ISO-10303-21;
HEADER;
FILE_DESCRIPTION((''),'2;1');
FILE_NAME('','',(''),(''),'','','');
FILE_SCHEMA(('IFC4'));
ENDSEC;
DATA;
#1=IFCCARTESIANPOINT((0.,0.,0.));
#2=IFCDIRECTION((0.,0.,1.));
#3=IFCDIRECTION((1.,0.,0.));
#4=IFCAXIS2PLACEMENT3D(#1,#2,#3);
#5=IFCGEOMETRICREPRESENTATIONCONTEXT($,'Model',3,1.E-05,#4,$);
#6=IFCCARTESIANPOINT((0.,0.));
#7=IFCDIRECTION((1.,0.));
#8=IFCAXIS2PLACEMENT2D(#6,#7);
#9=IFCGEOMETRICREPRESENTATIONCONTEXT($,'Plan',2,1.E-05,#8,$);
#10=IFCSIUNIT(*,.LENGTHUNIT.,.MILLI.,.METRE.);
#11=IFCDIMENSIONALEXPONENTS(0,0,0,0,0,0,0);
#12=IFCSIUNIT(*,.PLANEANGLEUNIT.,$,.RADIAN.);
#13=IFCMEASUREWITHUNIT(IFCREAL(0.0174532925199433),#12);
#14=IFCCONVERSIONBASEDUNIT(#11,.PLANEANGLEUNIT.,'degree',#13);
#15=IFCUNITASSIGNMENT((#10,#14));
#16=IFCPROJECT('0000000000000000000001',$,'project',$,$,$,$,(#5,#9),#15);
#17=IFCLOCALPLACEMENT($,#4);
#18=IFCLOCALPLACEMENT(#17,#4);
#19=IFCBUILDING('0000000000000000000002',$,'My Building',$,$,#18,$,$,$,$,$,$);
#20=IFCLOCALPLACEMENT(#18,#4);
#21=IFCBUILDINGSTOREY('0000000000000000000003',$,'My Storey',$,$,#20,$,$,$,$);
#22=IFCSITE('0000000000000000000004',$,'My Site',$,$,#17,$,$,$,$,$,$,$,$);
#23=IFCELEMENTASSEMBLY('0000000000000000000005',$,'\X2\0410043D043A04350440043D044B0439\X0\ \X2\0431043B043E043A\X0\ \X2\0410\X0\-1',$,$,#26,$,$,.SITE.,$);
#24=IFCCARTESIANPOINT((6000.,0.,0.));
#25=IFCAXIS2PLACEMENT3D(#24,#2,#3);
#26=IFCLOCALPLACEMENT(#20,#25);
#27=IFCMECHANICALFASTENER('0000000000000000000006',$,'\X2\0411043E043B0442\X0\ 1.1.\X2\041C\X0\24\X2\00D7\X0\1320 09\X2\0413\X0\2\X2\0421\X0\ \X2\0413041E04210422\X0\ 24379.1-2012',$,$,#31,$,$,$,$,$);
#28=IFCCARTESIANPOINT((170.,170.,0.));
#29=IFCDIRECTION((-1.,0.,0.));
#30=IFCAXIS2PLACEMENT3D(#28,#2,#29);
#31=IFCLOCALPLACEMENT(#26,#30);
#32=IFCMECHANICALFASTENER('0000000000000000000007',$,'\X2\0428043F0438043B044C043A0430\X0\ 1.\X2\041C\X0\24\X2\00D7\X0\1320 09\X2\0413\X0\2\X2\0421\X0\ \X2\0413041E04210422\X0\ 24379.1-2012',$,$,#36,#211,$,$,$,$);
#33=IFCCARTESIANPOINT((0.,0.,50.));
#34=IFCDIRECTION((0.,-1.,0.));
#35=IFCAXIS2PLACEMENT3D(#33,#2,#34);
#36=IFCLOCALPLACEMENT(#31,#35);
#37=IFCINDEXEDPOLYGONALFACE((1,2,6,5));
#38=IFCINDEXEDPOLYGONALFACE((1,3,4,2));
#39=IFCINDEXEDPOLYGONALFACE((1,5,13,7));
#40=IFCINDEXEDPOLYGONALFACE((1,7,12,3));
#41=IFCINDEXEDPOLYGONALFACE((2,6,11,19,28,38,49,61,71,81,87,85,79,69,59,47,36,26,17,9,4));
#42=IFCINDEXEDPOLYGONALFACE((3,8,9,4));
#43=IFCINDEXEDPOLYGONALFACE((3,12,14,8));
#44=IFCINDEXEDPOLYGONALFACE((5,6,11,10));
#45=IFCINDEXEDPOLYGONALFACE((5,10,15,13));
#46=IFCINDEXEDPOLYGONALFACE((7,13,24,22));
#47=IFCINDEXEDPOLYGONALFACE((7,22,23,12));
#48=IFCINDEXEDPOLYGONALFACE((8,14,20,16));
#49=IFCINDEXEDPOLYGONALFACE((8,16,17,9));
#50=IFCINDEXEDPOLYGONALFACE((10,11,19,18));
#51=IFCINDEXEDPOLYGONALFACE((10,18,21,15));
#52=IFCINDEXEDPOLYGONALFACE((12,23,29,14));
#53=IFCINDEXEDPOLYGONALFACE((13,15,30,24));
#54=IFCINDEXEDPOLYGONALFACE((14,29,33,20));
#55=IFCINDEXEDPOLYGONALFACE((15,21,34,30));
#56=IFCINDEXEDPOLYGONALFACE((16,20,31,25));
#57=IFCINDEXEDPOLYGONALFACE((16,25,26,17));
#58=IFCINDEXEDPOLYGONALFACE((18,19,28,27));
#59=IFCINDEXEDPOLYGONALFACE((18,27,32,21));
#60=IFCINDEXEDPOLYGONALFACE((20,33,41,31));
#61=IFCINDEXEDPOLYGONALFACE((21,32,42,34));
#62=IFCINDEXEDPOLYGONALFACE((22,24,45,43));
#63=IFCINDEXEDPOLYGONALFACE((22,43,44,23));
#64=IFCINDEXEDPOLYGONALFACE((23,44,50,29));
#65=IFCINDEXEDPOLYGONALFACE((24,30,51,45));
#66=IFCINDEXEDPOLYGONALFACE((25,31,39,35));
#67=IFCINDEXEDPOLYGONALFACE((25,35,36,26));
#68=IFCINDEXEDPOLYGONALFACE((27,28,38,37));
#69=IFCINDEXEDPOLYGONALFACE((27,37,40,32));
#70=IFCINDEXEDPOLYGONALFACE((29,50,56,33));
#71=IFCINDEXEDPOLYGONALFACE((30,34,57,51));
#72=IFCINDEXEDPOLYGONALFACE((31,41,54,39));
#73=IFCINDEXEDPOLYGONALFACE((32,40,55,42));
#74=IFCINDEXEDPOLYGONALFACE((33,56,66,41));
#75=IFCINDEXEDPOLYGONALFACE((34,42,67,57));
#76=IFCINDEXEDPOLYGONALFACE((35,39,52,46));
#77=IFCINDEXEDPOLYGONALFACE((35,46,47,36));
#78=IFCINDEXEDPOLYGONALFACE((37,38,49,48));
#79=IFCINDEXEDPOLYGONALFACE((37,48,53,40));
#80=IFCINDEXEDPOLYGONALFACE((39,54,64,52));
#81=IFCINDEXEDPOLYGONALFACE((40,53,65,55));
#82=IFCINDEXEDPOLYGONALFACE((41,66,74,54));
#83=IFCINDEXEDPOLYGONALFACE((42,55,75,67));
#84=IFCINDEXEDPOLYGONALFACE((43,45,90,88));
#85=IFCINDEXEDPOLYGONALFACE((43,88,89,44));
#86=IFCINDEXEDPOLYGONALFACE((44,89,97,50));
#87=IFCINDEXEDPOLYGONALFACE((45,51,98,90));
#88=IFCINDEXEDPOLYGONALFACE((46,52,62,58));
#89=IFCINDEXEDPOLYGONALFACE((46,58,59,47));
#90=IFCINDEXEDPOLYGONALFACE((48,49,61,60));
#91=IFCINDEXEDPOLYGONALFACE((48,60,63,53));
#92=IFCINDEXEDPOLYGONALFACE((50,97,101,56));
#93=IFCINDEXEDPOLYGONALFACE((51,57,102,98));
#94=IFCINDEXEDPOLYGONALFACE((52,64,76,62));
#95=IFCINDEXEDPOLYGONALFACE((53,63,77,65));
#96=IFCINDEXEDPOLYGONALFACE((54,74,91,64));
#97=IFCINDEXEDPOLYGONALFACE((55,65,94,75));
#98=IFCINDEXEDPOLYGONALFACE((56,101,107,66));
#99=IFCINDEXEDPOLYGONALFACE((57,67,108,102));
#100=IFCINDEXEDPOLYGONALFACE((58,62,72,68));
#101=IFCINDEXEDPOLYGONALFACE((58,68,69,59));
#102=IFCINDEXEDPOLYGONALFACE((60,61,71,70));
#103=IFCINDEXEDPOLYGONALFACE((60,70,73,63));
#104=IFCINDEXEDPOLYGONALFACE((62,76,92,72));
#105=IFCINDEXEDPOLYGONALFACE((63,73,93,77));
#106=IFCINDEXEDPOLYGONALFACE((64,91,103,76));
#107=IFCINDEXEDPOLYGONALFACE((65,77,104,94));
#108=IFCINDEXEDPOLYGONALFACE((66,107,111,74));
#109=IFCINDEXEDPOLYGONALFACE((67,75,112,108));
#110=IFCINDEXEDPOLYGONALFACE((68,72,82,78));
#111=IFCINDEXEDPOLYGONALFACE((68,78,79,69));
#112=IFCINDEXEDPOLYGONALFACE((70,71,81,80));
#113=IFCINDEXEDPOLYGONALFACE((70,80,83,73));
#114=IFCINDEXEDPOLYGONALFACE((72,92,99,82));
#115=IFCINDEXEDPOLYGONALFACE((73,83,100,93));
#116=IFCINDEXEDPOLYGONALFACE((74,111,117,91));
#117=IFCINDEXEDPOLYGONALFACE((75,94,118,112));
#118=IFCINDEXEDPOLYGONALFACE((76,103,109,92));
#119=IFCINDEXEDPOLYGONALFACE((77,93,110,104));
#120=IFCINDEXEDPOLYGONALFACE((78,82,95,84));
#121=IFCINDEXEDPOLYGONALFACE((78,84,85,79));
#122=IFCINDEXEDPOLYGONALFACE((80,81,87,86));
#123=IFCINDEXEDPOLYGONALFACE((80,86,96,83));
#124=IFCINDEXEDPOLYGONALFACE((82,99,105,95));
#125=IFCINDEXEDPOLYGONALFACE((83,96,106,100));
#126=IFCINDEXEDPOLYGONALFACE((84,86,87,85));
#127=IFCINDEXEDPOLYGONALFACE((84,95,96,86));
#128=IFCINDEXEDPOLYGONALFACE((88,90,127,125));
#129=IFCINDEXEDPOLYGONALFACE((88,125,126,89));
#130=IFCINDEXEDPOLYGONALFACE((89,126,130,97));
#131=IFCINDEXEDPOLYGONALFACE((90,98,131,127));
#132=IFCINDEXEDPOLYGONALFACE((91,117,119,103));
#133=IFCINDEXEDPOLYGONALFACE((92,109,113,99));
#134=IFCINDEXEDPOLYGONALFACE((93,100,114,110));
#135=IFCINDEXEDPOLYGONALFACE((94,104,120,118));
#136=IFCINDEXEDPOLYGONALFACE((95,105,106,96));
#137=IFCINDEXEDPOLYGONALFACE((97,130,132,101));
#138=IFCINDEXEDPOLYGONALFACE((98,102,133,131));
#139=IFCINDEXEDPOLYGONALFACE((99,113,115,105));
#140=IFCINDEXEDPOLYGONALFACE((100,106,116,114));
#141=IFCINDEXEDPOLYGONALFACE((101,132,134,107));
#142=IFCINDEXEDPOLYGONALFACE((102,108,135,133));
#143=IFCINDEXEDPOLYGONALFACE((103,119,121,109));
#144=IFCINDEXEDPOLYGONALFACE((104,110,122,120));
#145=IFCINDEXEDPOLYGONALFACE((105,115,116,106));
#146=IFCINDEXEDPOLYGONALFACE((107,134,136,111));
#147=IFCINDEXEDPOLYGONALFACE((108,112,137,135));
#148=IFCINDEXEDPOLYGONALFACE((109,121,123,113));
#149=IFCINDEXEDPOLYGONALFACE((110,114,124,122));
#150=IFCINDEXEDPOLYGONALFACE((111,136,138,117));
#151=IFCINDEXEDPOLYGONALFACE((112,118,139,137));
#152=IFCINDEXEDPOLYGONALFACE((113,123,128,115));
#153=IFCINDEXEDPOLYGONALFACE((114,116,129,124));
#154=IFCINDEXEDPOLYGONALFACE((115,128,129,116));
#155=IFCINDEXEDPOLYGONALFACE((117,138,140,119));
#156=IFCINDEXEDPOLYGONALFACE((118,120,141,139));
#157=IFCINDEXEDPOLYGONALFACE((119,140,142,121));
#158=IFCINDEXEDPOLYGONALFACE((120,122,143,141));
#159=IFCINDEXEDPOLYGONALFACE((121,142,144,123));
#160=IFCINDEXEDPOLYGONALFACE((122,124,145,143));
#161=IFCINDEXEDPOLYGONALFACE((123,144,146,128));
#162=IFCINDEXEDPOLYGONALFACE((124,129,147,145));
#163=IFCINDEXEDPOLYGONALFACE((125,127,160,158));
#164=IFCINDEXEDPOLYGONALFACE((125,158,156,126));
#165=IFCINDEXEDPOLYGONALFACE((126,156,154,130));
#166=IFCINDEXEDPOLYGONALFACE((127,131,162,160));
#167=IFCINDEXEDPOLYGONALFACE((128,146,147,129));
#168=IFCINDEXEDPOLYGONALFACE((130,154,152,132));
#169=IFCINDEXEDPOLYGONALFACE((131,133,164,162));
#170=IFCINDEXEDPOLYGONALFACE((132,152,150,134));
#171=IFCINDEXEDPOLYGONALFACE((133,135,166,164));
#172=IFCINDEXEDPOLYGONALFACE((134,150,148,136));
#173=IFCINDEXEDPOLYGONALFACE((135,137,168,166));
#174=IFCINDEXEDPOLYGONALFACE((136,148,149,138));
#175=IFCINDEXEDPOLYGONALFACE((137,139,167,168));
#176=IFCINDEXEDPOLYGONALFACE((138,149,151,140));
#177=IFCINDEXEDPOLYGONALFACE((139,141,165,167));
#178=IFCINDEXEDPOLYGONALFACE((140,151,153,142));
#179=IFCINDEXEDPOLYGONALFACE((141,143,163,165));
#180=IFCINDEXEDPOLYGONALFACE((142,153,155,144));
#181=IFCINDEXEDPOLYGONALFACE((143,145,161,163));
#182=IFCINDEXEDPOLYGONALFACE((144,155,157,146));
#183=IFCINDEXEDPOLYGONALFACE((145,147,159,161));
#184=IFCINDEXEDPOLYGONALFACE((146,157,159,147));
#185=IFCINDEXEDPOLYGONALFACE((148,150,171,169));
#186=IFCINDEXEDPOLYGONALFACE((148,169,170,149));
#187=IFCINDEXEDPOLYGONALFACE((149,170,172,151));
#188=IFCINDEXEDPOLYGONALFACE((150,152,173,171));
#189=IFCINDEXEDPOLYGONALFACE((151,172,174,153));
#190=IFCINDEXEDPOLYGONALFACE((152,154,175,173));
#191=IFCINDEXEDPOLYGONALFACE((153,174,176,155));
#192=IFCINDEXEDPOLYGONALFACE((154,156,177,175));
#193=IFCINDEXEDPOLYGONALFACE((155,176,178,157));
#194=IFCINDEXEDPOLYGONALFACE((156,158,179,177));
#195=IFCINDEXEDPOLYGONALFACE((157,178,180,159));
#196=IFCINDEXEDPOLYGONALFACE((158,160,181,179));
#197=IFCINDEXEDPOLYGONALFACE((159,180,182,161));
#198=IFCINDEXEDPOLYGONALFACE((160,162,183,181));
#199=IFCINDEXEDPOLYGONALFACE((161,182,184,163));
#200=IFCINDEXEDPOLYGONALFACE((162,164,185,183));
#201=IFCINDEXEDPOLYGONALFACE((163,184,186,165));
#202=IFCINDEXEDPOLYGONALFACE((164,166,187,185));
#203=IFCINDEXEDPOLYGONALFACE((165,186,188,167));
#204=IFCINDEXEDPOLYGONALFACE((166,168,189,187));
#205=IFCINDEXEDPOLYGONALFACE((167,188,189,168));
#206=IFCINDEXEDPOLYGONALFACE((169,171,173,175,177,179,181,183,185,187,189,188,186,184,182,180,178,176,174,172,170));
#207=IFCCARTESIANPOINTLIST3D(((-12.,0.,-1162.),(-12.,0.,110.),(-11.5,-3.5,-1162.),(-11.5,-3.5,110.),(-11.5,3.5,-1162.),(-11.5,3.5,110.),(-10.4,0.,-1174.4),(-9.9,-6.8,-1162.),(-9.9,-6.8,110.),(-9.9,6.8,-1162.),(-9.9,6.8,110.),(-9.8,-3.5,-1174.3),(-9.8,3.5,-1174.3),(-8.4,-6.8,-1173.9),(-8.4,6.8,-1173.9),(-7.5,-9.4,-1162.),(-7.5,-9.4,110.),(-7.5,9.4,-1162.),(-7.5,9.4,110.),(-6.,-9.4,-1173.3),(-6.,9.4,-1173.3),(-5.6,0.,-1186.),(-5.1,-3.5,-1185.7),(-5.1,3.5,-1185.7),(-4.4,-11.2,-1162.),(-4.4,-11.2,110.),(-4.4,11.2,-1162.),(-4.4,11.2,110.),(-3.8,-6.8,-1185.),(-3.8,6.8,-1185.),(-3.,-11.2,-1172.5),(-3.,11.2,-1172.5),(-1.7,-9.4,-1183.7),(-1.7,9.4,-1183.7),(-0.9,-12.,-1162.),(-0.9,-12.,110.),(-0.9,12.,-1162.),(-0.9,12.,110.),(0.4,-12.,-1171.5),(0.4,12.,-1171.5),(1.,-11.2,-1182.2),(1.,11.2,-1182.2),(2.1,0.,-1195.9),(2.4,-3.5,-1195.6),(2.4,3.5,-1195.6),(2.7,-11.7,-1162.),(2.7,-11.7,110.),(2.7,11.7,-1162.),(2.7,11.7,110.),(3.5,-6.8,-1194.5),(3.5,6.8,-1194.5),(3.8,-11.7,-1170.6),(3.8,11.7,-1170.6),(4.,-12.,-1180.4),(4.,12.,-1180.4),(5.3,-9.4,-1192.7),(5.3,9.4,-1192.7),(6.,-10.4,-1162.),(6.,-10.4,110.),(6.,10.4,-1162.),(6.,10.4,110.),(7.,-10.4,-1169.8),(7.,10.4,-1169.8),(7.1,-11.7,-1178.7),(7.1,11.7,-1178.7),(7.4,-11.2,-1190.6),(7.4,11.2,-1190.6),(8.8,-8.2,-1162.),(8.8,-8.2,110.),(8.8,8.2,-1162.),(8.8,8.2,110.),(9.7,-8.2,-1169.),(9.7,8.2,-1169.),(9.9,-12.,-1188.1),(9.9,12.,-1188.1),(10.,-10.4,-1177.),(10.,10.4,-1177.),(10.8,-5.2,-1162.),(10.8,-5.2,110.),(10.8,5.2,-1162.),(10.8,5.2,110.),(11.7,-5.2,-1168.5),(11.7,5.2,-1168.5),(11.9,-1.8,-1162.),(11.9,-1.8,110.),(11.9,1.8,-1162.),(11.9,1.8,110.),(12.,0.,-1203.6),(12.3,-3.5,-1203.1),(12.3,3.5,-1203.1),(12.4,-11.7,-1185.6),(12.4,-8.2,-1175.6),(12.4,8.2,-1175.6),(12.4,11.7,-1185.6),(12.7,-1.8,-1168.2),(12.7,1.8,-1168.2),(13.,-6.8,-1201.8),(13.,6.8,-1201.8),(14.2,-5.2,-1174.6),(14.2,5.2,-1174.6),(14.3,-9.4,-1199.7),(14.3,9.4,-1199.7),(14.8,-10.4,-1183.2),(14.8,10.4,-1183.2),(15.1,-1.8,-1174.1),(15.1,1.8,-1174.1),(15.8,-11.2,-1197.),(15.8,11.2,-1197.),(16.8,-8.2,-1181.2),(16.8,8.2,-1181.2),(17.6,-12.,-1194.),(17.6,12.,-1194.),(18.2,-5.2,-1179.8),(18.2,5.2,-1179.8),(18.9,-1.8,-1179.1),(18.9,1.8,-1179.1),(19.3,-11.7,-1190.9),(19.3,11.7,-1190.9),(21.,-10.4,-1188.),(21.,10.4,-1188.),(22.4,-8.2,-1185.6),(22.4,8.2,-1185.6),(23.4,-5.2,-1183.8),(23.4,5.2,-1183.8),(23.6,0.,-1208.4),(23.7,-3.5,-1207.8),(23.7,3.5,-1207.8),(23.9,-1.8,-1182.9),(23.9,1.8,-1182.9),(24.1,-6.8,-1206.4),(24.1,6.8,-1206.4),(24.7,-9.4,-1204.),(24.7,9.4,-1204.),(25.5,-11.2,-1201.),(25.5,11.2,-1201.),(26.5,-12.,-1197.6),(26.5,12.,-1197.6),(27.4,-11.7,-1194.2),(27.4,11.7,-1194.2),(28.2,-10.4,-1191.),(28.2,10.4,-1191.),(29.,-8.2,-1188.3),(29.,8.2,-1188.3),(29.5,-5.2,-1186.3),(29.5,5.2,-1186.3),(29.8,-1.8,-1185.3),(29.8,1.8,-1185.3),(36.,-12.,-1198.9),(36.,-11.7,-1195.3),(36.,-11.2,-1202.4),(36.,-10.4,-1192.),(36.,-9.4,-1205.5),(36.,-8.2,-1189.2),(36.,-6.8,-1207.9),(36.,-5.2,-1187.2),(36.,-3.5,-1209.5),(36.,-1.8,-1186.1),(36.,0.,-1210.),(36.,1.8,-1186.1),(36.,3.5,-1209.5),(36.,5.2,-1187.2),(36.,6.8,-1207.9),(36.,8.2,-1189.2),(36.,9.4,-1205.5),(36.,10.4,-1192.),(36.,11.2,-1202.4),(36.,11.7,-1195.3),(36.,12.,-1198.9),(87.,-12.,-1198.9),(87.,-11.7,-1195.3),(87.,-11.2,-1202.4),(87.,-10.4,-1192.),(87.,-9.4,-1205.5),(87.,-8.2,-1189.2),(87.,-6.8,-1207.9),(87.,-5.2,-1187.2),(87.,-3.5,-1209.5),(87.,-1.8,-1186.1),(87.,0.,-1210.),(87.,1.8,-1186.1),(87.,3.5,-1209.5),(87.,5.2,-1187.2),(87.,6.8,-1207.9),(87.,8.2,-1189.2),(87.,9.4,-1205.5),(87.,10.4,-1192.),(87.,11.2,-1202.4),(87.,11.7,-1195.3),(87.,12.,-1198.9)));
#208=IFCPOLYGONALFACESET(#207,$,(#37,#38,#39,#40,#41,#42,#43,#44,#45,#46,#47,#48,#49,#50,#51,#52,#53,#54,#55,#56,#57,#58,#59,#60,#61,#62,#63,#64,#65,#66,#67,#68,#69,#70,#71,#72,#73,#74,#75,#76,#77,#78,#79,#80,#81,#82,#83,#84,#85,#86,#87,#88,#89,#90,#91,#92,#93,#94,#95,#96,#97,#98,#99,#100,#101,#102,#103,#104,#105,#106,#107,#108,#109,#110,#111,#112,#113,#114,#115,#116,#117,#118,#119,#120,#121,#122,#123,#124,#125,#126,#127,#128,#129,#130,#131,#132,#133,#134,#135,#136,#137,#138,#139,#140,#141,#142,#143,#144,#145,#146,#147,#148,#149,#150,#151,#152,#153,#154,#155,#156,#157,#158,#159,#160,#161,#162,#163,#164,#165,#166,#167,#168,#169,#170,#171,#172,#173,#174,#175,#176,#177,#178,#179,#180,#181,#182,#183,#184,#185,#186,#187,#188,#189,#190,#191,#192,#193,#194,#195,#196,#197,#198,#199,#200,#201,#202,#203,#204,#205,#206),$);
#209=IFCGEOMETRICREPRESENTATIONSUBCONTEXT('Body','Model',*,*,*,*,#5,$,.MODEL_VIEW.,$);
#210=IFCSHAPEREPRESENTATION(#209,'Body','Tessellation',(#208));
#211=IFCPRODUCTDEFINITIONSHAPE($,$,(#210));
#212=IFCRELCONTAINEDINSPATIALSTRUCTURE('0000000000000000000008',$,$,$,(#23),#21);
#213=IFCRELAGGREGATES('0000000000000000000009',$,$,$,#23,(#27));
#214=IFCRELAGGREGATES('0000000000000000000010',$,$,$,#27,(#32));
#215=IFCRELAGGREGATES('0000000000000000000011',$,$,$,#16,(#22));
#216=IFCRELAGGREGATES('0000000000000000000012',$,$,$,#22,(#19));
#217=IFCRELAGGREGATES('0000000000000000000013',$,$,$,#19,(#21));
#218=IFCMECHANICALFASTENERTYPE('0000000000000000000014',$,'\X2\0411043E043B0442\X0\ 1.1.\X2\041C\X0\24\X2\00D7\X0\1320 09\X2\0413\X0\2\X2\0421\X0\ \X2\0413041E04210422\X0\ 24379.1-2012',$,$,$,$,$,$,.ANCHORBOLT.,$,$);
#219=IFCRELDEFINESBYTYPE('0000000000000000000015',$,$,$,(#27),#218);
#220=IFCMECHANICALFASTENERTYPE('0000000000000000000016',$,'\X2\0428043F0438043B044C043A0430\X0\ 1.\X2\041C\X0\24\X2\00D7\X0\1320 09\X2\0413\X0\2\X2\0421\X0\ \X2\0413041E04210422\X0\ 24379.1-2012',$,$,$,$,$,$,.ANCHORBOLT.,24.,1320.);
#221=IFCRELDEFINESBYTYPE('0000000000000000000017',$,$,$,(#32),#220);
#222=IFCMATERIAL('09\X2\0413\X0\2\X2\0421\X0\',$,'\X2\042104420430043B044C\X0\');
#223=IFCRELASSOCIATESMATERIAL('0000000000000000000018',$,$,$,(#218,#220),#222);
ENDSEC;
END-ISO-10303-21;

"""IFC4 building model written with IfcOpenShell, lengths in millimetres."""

from ifc_helpers import new_model, entity, si_unit, converted_unit, frame, origin_with_axes, origin_2d_with_axis, place, context, subcontext, project, spatial, source, transform, mapped, material, type_object, type_shapes, element, aggregate, save


model = new_model("IFC4")

# Units and contexts
model_context = context("Model", 3, precision=1e-05, world=origin_with_axes())
plan_context = context("Plan", 2, precision=1e-05, world=origin_2d_with_axis())
body_context = subcontext(model_context, "Body", "Model", "MODEL_VIEW")
ifc_project = project(units=[si_unit("LENGTHUNIT", "METRE", prefix="MILLI"), converted_unit("PLANEANGLEUNIT", "degree", entity("IfcReal", 0.0174532925199433), si_unit("PLANEANGLEUNIT", "RADIAN"), dimensions=[0, 0, 0, 0, 0, 0, 0])], contexts=[model_context, plan_context])

# Site, building, storey
site_placement = place(None, origin_with_axes())
site = spatial("IfcSite", under=ifc_project, at=site_placement, Name="My Site")
building_placement = place(site_placement, origin_with_axes())
building = spatial("IfcBuilding", under=site, at=building_placement, Name="My Building")
storey_placement = place(building_placement, origin_with_axes())
storey = spatial("IfcBuildingStorey", under=building, at=storey_placement, Name="My Storey")

# Element assembly, mechanical fasteners
assembly_1_placement = place(storey_placement, frame((6000.0, 0.0, 0.0), z_axis=(0.0, 0.0, 1.0), x_axis=(1.0, 0.0, 0.0)))
assembly_1 = element("IfcElementAssembly", 1, at=assembly_1_placement, inside=storey, Name="Анкерный блок А-1", AssemblyPlace="SITE")
ifc_material_1 = material(Name="09Г2С", Category="Сталь")
mechanical_fastener_type_1 = type_object("IfcMechanicalFastenerType", Name="Болт 1.1.М24×1320 09Г2С ГОСТ 24379.1-2012", PredefinedType="ANCHORBOLT", material=ifc_material_1)
mechanical_fastener_type_2 = type_object("IfcMechanicalFastenerType", Name="Шпилька 1.М24×1320 09Г2С ГОСТ 24379.1-2012", NominalDiameter=24.0, NominalLength=1320.0, PredefinedType="ANCHORBOLT", material=ifc_material_1)
shared_shape_1 = source(frame((0.0, 0.0, 110.0), z_axis=(0.0, 0.0, 1.0), x_axis=(1.0, 0.0, 0.0)), body_context, "Body", "AdvancedSweptSolid", [
    entity("IfcSweptDiskSolid", entity("IfcIndexedPolyCurve", entity("IfcCartesianPointList3D", [[0.0, 0.0, 0.0], [0.0, 0.0, -1272.0], [10.5, 0.0, -1297.5], [36.0, 0.0, -1308.0], [87.0, 0.0, -1308.0]]), [entity("IfcLineIndex", [1, 2]), entity("IfcArcIndex", [2, 3, 4]), entity("IfcLineIndex", [4, 5])]), 12.0),
])
type_shapes(mechanical_fastener_type_2, [shared_shape_1])
mechanical_fastener_1_placement = place(assembly_1_placement, frame((170.0, 170.0, 0.0), z_axis=(0.0, 0.0, 1.0), x_axis=(-1.0, 0.0, 0.0)))
mechanical_fastener_1 = element("IfcMechanicalFastener", 2, at=mechanical_fastener_1_placement, type_object=mechanical_fastener_type_1, Name="Болт 1.1.М24×1320 09Г2С ГОСТ 24379.1-2012")
mechanical_fastener_2_placement = place(mechanical_fastener_1_placement, frame((0.0, 0.0, 50.0), z_axis=(0.0, 0.0, 1.0), x_axis=(0.0, -1.0, 0.0)))
mechanical_fastener_2 = element("IfcMechanicalFastener", 3, at=mechanical_fastener_2_placement, type_object=mechanical_fastener_type_2, Name="Шпилька 1.М24×1320 09Г2С ГОСТ 24379.1-2012", context=body_context, shape_type="MappedRepresentation", body=[
    mapped(shared_shape_1, transform((0.0, 0.0, 0.0), x_axis=(1.0, 0.0, 0.0), y_axis=(0.0, 1.0, 0.0), z_axis=(0.0, 0.0, 1.0), scale=1.0)),
])
aggregate(assembly_1, [mechanical_fastener_1])

aggregate(mechanical_fastener_1, [mechanical_fastener_2])

save(model, "model.ifc")
